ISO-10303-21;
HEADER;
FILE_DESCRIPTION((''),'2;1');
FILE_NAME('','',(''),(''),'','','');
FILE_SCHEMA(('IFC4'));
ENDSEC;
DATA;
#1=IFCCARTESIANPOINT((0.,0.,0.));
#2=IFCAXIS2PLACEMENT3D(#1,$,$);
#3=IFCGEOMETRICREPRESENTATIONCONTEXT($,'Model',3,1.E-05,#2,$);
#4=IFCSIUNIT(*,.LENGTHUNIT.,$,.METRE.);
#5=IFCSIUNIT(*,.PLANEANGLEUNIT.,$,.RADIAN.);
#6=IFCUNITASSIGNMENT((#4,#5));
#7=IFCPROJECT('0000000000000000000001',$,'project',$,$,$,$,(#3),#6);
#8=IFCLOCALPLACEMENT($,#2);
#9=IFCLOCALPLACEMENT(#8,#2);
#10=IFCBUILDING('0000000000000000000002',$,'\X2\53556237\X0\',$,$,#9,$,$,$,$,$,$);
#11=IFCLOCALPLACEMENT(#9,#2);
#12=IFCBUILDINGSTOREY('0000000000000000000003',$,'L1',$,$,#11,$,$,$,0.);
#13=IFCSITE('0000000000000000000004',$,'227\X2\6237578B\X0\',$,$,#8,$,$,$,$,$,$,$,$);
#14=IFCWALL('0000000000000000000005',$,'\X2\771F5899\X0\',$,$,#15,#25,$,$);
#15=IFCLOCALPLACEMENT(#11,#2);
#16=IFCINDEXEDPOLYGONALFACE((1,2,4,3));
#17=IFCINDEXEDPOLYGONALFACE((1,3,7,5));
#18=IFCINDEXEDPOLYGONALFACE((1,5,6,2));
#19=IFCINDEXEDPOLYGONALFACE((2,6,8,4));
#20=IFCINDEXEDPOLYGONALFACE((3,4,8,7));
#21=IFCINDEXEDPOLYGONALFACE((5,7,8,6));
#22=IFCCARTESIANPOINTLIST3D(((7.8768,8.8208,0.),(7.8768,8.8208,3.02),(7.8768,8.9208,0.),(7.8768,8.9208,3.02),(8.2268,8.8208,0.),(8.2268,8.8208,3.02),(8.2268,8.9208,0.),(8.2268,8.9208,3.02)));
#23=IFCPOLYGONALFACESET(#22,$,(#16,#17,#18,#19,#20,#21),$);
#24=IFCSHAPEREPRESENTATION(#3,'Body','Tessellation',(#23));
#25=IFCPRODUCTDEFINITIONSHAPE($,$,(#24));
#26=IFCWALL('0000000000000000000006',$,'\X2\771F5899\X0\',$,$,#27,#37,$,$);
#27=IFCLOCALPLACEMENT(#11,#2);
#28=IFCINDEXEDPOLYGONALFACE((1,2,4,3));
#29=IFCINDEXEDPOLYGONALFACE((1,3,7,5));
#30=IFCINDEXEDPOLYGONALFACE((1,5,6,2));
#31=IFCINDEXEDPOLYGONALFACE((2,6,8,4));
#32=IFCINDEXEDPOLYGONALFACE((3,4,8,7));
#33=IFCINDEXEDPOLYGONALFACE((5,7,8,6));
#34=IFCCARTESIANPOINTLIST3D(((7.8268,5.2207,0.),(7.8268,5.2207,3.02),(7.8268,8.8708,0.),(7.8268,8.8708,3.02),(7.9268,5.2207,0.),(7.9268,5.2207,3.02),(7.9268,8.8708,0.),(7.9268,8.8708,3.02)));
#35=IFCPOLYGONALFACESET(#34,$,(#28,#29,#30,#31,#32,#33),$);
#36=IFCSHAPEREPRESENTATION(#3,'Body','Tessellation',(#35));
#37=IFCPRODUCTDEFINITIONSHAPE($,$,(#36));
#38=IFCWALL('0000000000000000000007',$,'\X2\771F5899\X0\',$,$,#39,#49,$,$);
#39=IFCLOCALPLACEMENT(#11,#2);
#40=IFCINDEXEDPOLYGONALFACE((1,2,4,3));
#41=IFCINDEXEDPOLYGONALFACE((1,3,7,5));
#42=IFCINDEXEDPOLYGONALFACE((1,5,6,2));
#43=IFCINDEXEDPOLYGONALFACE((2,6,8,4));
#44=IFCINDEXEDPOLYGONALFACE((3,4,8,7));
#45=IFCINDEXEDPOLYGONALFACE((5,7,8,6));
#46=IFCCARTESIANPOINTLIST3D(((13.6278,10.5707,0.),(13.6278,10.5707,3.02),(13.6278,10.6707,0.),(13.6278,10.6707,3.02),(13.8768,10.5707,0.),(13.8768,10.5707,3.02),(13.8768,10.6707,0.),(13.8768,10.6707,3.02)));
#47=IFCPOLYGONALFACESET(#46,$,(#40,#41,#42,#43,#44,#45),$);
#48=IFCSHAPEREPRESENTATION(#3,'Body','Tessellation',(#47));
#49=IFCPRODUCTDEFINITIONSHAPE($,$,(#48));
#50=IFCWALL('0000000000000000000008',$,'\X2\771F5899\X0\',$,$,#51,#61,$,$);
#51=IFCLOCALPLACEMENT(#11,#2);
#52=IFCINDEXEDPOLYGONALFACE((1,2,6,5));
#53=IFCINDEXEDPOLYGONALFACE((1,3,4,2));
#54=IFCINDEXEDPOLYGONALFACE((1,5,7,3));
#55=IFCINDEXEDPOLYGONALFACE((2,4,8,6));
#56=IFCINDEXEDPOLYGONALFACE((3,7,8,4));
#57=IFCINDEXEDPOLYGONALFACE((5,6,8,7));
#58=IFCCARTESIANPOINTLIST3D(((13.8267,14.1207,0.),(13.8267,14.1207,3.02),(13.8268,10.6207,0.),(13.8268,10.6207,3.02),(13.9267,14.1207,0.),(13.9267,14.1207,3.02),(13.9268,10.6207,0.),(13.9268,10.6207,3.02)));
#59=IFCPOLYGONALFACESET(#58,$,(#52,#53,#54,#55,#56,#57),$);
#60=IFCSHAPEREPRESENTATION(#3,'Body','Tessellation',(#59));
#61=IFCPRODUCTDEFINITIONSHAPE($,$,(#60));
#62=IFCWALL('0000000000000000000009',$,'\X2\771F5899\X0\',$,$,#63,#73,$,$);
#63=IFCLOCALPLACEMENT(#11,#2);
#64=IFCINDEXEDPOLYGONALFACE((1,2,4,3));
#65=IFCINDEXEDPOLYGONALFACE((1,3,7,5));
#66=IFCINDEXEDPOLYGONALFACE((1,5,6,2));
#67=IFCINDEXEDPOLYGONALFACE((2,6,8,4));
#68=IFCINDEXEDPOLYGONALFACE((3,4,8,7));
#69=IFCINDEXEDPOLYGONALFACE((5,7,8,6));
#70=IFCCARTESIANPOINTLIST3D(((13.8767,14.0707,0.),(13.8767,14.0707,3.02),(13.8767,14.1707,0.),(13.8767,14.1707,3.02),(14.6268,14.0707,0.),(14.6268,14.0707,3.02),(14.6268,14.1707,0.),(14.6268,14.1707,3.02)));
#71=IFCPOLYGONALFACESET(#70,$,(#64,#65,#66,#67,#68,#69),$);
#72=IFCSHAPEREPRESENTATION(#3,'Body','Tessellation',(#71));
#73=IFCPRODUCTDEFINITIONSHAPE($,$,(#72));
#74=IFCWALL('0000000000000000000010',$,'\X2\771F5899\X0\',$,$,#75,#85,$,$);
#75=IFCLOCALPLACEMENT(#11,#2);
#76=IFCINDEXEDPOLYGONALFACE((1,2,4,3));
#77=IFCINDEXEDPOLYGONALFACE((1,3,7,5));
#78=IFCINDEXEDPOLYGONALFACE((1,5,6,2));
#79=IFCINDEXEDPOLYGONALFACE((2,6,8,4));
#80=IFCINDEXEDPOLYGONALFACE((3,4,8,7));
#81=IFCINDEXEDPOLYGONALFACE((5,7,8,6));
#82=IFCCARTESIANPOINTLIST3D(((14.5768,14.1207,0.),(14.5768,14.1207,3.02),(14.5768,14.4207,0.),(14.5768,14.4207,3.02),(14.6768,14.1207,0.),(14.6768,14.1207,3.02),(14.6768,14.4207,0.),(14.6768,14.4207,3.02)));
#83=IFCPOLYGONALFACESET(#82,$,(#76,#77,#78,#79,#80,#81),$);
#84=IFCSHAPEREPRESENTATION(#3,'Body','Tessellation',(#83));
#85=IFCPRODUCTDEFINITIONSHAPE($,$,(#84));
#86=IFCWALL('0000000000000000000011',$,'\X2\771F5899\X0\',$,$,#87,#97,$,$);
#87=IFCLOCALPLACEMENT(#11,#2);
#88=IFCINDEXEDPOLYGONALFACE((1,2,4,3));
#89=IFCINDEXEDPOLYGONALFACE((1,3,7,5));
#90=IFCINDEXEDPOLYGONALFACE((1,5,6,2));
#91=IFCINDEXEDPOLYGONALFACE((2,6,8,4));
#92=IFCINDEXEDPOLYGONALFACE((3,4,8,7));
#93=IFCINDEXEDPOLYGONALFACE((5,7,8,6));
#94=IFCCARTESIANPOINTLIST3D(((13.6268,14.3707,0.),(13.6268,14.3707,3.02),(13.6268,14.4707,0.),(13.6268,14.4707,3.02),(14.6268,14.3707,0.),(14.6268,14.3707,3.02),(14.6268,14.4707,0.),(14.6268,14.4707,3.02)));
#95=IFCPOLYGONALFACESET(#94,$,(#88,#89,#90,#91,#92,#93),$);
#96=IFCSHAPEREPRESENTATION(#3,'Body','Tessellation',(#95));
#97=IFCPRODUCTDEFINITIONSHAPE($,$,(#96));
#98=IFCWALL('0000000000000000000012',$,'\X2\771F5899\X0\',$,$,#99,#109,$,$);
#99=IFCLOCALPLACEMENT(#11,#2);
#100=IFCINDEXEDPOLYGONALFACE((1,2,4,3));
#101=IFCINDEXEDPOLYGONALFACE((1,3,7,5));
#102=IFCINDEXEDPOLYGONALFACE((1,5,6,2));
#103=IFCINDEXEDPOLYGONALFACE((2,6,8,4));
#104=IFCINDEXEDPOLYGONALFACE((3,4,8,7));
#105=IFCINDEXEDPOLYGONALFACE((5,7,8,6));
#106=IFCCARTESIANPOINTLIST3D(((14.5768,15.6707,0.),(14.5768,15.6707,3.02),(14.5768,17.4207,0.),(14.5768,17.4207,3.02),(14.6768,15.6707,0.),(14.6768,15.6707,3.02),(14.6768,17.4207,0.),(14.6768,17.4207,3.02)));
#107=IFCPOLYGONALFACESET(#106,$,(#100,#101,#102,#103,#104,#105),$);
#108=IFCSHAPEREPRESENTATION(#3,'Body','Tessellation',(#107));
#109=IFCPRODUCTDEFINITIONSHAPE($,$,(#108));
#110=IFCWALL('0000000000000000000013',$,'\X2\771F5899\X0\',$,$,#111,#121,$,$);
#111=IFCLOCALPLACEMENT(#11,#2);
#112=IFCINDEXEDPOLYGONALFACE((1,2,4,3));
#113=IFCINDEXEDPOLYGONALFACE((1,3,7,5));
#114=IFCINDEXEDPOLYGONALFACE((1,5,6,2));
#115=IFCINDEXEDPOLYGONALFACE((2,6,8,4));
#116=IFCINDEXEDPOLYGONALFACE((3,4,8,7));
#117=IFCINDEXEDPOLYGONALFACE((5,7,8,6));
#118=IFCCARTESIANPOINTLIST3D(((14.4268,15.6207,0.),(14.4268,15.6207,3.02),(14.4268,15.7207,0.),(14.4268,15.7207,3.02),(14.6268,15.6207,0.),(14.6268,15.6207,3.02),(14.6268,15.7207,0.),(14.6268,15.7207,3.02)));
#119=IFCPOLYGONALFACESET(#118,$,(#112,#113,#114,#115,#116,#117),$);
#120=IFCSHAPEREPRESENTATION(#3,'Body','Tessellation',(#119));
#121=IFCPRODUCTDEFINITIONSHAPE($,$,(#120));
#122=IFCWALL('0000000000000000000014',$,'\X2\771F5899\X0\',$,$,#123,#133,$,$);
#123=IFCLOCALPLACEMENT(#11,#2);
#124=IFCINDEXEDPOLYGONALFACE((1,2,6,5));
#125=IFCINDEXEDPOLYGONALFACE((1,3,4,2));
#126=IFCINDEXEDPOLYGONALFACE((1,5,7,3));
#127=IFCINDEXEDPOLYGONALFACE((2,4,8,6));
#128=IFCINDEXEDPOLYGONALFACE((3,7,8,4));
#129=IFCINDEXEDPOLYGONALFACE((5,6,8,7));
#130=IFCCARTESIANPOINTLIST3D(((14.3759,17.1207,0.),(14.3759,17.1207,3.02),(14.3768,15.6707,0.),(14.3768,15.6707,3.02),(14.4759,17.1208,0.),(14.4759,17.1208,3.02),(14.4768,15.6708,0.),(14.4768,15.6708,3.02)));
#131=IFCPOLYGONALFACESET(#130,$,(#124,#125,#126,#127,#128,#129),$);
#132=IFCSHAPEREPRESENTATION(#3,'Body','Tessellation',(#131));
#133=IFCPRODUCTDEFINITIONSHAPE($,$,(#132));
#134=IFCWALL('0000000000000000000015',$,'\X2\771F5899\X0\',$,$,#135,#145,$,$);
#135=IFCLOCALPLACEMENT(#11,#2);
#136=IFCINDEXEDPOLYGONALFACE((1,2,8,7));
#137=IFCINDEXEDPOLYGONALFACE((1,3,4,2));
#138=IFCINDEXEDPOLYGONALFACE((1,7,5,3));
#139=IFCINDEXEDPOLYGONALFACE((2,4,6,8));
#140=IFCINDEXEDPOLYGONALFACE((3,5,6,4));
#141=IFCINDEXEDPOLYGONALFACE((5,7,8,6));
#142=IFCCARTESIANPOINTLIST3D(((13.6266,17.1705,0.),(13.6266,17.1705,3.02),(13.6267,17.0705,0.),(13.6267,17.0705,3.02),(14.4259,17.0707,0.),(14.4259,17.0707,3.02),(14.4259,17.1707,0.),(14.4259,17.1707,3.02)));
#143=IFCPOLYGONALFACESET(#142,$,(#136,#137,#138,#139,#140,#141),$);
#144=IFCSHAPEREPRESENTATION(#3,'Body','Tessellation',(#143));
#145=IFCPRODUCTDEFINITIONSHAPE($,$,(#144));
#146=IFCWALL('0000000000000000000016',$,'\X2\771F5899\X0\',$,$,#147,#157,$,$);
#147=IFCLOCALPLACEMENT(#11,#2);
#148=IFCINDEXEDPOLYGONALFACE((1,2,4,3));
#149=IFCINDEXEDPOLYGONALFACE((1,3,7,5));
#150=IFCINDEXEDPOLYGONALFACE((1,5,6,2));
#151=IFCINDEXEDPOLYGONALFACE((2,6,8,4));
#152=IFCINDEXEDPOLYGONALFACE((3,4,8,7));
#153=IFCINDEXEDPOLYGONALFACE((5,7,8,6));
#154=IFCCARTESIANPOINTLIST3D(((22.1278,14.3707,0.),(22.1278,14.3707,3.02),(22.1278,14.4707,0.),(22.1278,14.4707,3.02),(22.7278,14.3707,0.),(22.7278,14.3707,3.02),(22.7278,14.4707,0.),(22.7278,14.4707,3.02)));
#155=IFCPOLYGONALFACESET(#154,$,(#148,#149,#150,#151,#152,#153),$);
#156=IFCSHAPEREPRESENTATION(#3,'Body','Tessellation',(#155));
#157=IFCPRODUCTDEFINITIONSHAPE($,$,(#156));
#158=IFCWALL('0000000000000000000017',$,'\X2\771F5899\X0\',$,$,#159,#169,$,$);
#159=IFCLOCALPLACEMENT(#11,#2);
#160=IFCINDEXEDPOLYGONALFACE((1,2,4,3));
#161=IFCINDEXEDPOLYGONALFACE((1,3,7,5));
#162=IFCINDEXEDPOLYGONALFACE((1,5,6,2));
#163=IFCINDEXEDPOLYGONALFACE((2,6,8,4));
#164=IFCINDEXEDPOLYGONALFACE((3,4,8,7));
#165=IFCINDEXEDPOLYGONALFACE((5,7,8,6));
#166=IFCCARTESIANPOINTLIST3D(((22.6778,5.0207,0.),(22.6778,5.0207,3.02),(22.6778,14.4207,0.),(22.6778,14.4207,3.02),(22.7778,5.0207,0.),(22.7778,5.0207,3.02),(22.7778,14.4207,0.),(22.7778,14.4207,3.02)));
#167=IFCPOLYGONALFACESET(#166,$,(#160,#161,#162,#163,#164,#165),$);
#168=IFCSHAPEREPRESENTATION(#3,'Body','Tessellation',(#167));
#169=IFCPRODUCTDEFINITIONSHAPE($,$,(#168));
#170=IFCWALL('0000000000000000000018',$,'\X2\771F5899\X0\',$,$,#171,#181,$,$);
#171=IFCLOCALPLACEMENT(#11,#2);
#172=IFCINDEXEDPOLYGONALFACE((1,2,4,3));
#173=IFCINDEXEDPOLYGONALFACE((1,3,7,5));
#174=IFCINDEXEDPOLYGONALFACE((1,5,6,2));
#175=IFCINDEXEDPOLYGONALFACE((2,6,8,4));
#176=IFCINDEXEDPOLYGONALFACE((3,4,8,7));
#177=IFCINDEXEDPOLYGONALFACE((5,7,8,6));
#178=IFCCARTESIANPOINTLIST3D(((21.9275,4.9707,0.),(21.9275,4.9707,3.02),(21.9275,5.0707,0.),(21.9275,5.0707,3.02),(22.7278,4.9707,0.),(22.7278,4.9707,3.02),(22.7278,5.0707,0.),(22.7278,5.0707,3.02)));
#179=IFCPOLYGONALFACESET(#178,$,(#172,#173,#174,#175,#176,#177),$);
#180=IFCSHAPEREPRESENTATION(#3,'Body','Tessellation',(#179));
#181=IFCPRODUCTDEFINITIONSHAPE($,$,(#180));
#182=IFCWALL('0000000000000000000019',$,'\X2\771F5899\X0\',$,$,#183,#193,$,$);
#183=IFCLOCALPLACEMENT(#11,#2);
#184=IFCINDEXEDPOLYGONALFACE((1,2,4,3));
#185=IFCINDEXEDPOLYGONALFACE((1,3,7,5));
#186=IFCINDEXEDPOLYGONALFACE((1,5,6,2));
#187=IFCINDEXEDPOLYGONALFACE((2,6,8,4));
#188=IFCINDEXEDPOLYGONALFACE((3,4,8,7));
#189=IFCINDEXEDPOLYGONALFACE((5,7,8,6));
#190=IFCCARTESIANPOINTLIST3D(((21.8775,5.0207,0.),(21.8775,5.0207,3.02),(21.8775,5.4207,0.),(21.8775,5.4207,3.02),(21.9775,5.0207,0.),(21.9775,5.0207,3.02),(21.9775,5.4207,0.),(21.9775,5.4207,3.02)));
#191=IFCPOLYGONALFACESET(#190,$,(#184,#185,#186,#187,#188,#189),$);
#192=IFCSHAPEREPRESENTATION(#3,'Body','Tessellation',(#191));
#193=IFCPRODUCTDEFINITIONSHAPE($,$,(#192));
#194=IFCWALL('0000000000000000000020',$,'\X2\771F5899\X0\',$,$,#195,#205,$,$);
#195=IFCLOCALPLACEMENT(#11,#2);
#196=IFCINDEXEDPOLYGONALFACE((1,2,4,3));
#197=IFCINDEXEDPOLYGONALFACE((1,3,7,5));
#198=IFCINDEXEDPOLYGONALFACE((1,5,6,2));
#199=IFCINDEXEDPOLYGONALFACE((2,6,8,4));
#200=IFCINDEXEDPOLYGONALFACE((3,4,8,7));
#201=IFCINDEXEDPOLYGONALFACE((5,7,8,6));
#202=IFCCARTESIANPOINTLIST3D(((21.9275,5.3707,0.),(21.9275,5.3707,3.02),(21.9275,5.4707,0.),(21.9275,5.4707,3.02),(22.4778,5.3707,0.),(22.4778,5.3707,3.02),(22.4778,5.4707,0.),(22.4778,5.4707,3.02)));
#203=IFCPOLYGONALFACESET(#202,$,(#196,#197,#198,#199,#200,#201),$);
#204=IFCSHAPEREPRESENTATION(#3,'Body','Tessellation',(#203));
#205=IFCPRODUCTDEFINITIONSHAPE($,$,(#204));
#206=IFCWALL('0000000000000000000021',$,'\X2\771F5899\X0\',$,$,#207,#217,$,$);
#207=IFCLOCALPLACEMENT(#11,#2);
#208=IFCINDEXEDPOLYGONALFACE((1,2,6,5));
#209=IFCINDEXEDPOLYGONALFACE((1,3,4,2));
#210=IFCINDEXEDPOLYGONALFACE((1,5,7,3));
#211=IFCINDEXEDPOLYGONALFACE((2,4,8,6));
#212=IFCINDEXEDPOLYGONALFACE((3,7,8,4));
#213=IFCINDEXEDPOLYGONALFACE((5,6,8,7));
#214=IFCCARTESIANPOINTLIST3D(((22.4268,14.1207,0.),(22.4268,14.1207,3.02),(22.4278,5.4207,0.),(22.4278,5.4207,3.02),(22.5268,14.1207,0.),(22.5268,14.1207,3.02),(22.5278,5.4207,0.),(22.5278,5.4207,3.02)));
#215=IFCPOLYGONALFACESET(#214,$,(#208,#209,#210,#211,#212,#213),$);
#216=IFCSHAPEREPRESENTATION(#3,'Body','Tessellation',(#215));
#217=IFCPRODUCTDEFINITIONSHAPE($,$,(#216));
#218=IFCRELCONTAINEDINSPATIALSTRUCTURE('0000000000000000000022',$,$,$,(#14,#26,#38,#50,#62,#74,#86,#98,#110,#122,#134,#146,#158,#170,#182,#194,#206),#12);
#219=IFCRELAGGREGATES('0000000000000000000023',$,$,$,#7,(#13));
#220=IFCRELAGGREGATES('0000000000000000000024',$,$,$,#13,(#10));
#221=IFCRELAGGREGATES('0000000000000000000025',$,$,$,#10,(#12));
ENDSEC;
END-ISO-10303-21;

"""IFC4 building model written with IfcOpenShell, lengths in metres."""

from ifc_helpers import new_model, si_unit, origin, place, context, project, spatial, polyline, outline, extrude, element, save


model = new_model("IFC4")

# Units and contexts
model_context = context("Model", 3, precision=1e-05, world=origin())
ifc_project = project(units=[si_unit("LENGTHUNIT", "METRE"), si_unit("PLANEANGLEUNIT", "RADIAN")], contexts=[model_context])

# Site, building, storey
site_placement = place(None, origin())
site = spatial("IfcSite", under=ifc_project, at=site_placement, Name="227户型")
building_placement = place(site_placement, origin())
building = spatial("IfcBuilding", under=site, at=building_placement, Name="单户")
storey_placement = place(building_placement, origin())
storey = spatial("IfcBuildingStorey", under=building, at=storey_placement, Name="L1", Elevation=0.0)

# Walls
wall_1_placement = place(storey_placement, origin())
element("IfcWall", 1, at=wall_1_placement, inside=storey, Name="真墙", context=model_context, shape_type="SweptSolid", body=[
    extrude(outline(polyline([(8.2268, 8.8208), (7.8768, 8.8208), (7.8768, 8.9208), (8.2268, 8.9208), (8.2268, 8.8208)])), origin(), (0.0, 0.0, 1.0), 3.02),
])
wall_2_placement = place(storey_placement, origin())
element("IfcWall", 2, at=wall_2_placement, inside=storey, Name="真墙", context=model_context, shape_type="SweptSolid", body=[
    extrude(outline(polyline([(7.9268, 8.8708), (7.9268, 5.2207), (7.8268, 5.2207), (7.8268, 8.8708), (7.9268, 8.8708)])), origin(), (0.0, 0.0, 1.0), 3.02),
])
wall_3_placement = place(storey_placement, origin())
element("IfcWall", 3, at=wall_3_placement, inside=storey, Name="真墙", context=model_context, shape_type="SweptSolid", body=[
    extrude(outline(polyline([(13.6278, 10.6707), (13.8768, 10.6707), (13.8768, 10.5707), (13.6278, 10.5707), (13.6278, 10.6707)])), origin(), (0.0, 0.0, 1.0), 3.02),
])
wall_4_placement = place(storey_placement, origin())
element("IfcWall", 4, at=wall_4_placement, inside=storey, Name="真墙", context=model_context, shape_type="SweptSolid", body=[
    extrude(outline(polyline([(13.8268, 10.6207), (13.8267, 14.1207), (13.9267, 14.1207), (13.9268, 10.6207), (13.8268, 10.6207)])), origin(), (0.0, 0.0, 1.0), 3.02),
])
wall_5_placement = place(storey_placement, origin())
element("IfcWall", 5, at=wall_5_placement, inside=storey, Name="真墙", context=model_context, shape_type="SweptSolid", body=[
    extrude(outline(polyline([(13.8767, 14.1707), (14.6268, 14.1707), (14.6268, 14.0707), (13.8767, 14.0707), (13.8767, 14.1707)])), origin(), (0.0, 0.0, 1.0), 3.02),
])
wall_6_placement = place(storey_placement, origin())
element("IfcWall", 6, at=wall_6_placement, inside=storey, Name="真墙", context=model_context, shape_type="SweptSolid", body=[
    extrude(outline(polyline([(14.5768, 14.1207), (14.5768, 14.4207), (14.6768, 14.4207), (14.6768, 14.1207), (14.5768, 14.1207)])), origin(), (0.0, 0.0, 1.0), 3.02),
])
wall_7_placement = place(storey_placement, origin())
element("IfcWall", 7, at=wall_7_placement, inside=storey, Name="真墙", context=model_context, shape_type="SweptSolid", body=[
    extrude(outline(polyline([(14.6268, 14.3707), (13.6268, 14.3707), (13.6268, 14.4707), (14.6268, 14.4707), (14.6268, 14.3707)])), origin(), (0.0, 0.0, 1.0), 3.02),
])

# Walls
wall_8_placement = place(storey_placement, origin())
element("IfcWall", 8, at=wall_8_placement, inside=storey, Name="真墙", context=model_context, shape_type="SweptSolid", body=[
    extrude(outline(polyline([(14.6768, 17.4207), (14.6768, 15.6707), (14.5768, 15.6707), (14.5768, 17.4207), (14.6768, 17.4207)])), origin(), (0.0, 0.0, 1.0), 3.02),
])
wall_9_placement = place(storey_placement, origin())
element("IfcWall", 9, at=wall_9_placement, inside=storey, Name="真墙", context=model_context, shape_type="SweptSolid", body=[
    extrude(outline(polyline([(14.6268, 15.6207), (14.4268, 15.6207), (14.4268, 15.7207), (14.6268, 15.7207), (14.6268, 15.6207)])), origin(), (0.0, 0.0, 1.0), 3.02),
])
wall_10_placement = place(storey_placement, origin())
element("IfcWall", 10, at=wall_10_placement, inside=storey, Name="真墙", context=model_context, shape_type="SweptSolid", body=[
    extrude(outline(polyline([(14.3768, 15.6707), (14.3759, 17.1207), (14.4759, 17.1208), (14.4768, 15.6708), (14.3768, 15.6707)])), origin(), (0.0, 0.0, 1.0), 3.02),
])
wall_11_placement = place(storey_placement, origin())
element("IfcWall", 11, at=wall_11_placement, inside=storey, Name="真墙", context=model_context, shape_type="SweptSolid", body=[
    extrude(outline(polyline([(14.4259, 17.0707), (13.6267, 17.0705), (13.6266, 17.1705), (14.4259, 17.1707), (14.4259, 17.0707)])), origin(), (0.0, 0.0, 1.0), 3.02),
])
wall_12_placement = place(storey_placement, origin())
element("IfcWall", 12, at=wall_12_placement, inside=storey, Name="真墙", context=model_context, shape_type="SweptSolid", body=[
    extrude(outline(polyline([(22.1278, 14.4707), (22.7278, 14.4707), (22.7278, 14.3707), (22.1278, 14.3707), (22.1278, 14.4707)])), origin(), (0.0, 0.0, 1.0), 3.02),
])
wall_13_placement = place(storey_placement, origin())
element("IfcWall", 13, at=wall_13_placement, inside=storey, Name="真墙", context=model_context, shape_type="SweptSolid", body=[
    extrude(outline(polyline([(22.7778, 14.4207), (22.7778, 5.0207), (22.6778, 5.0207), (22.6778, 14.4207), (22.7778, 14.4207)])), origin(), (0.0, 0.0, 1.0), 3.02),
])
wall_14_placement = place(storey_placement, origin())
element("IfcWall", 14, at=wall_14_placement, inside=storey, Name="真墙", context=model_context, shape_type="SweptSolid", body=[
    extrude(outline(polyline([(22.7278, 4.9707), (21.9275, 4.9707), (21.9275, 5.0707), (22.7278, 5.0707), (22.7278, 4.9707)])), origin(), (0.0, 0.0, 1.0), 3.02),
])
wall_15_placement = place(storey_placement, origin())
element("IfcWall", 15, at=wall_15_placement, inside=storey, Name="真墙", context=model_context, shape_type="SweptSolid", body=[
    extrude(outline(polyline([(21.8775, 5.0207), (21.8775, 5.4207), (21.9775, 5.4207), (21.9775, 5.0207), (21.8775, 5.0207)])), origin(), (0.0, 0.0, 1.0), 3.02),
])
wall_16_placement = place(storey_placement, origin())
element("IfcWall", 16, at=wall_16_placement, inside=storey, Name="真墙", context=model_context, shape_type="SweptSolid", body=[
    extrude(outline(polyline([(21.9275, 5.4707), (22.4778, 5.4707), (22.4778, 5.3707), (21.9275, 5.3707), (21.9275, 5.4707)])), origin(), (0.0, 0.0, 1.0), 3.02),
])
wall_17_placement = place(storey_placement, origin())
element("IfcWall", 17, at=wall_17_placement, inside=storey, Name="真墙", context=model_context, shape_type="SweptSolid", body=[
    extrude(outline(polyline([(22.4278, 5.4207), (22.4268, 14.1207), (22.5268, 14.1207), (22.5278, 5.4207), (22.4278, 5.4207)])), origin(), (0.0, 0.0, 1.0), 3.02),
])

save(model, "model.ifc")
